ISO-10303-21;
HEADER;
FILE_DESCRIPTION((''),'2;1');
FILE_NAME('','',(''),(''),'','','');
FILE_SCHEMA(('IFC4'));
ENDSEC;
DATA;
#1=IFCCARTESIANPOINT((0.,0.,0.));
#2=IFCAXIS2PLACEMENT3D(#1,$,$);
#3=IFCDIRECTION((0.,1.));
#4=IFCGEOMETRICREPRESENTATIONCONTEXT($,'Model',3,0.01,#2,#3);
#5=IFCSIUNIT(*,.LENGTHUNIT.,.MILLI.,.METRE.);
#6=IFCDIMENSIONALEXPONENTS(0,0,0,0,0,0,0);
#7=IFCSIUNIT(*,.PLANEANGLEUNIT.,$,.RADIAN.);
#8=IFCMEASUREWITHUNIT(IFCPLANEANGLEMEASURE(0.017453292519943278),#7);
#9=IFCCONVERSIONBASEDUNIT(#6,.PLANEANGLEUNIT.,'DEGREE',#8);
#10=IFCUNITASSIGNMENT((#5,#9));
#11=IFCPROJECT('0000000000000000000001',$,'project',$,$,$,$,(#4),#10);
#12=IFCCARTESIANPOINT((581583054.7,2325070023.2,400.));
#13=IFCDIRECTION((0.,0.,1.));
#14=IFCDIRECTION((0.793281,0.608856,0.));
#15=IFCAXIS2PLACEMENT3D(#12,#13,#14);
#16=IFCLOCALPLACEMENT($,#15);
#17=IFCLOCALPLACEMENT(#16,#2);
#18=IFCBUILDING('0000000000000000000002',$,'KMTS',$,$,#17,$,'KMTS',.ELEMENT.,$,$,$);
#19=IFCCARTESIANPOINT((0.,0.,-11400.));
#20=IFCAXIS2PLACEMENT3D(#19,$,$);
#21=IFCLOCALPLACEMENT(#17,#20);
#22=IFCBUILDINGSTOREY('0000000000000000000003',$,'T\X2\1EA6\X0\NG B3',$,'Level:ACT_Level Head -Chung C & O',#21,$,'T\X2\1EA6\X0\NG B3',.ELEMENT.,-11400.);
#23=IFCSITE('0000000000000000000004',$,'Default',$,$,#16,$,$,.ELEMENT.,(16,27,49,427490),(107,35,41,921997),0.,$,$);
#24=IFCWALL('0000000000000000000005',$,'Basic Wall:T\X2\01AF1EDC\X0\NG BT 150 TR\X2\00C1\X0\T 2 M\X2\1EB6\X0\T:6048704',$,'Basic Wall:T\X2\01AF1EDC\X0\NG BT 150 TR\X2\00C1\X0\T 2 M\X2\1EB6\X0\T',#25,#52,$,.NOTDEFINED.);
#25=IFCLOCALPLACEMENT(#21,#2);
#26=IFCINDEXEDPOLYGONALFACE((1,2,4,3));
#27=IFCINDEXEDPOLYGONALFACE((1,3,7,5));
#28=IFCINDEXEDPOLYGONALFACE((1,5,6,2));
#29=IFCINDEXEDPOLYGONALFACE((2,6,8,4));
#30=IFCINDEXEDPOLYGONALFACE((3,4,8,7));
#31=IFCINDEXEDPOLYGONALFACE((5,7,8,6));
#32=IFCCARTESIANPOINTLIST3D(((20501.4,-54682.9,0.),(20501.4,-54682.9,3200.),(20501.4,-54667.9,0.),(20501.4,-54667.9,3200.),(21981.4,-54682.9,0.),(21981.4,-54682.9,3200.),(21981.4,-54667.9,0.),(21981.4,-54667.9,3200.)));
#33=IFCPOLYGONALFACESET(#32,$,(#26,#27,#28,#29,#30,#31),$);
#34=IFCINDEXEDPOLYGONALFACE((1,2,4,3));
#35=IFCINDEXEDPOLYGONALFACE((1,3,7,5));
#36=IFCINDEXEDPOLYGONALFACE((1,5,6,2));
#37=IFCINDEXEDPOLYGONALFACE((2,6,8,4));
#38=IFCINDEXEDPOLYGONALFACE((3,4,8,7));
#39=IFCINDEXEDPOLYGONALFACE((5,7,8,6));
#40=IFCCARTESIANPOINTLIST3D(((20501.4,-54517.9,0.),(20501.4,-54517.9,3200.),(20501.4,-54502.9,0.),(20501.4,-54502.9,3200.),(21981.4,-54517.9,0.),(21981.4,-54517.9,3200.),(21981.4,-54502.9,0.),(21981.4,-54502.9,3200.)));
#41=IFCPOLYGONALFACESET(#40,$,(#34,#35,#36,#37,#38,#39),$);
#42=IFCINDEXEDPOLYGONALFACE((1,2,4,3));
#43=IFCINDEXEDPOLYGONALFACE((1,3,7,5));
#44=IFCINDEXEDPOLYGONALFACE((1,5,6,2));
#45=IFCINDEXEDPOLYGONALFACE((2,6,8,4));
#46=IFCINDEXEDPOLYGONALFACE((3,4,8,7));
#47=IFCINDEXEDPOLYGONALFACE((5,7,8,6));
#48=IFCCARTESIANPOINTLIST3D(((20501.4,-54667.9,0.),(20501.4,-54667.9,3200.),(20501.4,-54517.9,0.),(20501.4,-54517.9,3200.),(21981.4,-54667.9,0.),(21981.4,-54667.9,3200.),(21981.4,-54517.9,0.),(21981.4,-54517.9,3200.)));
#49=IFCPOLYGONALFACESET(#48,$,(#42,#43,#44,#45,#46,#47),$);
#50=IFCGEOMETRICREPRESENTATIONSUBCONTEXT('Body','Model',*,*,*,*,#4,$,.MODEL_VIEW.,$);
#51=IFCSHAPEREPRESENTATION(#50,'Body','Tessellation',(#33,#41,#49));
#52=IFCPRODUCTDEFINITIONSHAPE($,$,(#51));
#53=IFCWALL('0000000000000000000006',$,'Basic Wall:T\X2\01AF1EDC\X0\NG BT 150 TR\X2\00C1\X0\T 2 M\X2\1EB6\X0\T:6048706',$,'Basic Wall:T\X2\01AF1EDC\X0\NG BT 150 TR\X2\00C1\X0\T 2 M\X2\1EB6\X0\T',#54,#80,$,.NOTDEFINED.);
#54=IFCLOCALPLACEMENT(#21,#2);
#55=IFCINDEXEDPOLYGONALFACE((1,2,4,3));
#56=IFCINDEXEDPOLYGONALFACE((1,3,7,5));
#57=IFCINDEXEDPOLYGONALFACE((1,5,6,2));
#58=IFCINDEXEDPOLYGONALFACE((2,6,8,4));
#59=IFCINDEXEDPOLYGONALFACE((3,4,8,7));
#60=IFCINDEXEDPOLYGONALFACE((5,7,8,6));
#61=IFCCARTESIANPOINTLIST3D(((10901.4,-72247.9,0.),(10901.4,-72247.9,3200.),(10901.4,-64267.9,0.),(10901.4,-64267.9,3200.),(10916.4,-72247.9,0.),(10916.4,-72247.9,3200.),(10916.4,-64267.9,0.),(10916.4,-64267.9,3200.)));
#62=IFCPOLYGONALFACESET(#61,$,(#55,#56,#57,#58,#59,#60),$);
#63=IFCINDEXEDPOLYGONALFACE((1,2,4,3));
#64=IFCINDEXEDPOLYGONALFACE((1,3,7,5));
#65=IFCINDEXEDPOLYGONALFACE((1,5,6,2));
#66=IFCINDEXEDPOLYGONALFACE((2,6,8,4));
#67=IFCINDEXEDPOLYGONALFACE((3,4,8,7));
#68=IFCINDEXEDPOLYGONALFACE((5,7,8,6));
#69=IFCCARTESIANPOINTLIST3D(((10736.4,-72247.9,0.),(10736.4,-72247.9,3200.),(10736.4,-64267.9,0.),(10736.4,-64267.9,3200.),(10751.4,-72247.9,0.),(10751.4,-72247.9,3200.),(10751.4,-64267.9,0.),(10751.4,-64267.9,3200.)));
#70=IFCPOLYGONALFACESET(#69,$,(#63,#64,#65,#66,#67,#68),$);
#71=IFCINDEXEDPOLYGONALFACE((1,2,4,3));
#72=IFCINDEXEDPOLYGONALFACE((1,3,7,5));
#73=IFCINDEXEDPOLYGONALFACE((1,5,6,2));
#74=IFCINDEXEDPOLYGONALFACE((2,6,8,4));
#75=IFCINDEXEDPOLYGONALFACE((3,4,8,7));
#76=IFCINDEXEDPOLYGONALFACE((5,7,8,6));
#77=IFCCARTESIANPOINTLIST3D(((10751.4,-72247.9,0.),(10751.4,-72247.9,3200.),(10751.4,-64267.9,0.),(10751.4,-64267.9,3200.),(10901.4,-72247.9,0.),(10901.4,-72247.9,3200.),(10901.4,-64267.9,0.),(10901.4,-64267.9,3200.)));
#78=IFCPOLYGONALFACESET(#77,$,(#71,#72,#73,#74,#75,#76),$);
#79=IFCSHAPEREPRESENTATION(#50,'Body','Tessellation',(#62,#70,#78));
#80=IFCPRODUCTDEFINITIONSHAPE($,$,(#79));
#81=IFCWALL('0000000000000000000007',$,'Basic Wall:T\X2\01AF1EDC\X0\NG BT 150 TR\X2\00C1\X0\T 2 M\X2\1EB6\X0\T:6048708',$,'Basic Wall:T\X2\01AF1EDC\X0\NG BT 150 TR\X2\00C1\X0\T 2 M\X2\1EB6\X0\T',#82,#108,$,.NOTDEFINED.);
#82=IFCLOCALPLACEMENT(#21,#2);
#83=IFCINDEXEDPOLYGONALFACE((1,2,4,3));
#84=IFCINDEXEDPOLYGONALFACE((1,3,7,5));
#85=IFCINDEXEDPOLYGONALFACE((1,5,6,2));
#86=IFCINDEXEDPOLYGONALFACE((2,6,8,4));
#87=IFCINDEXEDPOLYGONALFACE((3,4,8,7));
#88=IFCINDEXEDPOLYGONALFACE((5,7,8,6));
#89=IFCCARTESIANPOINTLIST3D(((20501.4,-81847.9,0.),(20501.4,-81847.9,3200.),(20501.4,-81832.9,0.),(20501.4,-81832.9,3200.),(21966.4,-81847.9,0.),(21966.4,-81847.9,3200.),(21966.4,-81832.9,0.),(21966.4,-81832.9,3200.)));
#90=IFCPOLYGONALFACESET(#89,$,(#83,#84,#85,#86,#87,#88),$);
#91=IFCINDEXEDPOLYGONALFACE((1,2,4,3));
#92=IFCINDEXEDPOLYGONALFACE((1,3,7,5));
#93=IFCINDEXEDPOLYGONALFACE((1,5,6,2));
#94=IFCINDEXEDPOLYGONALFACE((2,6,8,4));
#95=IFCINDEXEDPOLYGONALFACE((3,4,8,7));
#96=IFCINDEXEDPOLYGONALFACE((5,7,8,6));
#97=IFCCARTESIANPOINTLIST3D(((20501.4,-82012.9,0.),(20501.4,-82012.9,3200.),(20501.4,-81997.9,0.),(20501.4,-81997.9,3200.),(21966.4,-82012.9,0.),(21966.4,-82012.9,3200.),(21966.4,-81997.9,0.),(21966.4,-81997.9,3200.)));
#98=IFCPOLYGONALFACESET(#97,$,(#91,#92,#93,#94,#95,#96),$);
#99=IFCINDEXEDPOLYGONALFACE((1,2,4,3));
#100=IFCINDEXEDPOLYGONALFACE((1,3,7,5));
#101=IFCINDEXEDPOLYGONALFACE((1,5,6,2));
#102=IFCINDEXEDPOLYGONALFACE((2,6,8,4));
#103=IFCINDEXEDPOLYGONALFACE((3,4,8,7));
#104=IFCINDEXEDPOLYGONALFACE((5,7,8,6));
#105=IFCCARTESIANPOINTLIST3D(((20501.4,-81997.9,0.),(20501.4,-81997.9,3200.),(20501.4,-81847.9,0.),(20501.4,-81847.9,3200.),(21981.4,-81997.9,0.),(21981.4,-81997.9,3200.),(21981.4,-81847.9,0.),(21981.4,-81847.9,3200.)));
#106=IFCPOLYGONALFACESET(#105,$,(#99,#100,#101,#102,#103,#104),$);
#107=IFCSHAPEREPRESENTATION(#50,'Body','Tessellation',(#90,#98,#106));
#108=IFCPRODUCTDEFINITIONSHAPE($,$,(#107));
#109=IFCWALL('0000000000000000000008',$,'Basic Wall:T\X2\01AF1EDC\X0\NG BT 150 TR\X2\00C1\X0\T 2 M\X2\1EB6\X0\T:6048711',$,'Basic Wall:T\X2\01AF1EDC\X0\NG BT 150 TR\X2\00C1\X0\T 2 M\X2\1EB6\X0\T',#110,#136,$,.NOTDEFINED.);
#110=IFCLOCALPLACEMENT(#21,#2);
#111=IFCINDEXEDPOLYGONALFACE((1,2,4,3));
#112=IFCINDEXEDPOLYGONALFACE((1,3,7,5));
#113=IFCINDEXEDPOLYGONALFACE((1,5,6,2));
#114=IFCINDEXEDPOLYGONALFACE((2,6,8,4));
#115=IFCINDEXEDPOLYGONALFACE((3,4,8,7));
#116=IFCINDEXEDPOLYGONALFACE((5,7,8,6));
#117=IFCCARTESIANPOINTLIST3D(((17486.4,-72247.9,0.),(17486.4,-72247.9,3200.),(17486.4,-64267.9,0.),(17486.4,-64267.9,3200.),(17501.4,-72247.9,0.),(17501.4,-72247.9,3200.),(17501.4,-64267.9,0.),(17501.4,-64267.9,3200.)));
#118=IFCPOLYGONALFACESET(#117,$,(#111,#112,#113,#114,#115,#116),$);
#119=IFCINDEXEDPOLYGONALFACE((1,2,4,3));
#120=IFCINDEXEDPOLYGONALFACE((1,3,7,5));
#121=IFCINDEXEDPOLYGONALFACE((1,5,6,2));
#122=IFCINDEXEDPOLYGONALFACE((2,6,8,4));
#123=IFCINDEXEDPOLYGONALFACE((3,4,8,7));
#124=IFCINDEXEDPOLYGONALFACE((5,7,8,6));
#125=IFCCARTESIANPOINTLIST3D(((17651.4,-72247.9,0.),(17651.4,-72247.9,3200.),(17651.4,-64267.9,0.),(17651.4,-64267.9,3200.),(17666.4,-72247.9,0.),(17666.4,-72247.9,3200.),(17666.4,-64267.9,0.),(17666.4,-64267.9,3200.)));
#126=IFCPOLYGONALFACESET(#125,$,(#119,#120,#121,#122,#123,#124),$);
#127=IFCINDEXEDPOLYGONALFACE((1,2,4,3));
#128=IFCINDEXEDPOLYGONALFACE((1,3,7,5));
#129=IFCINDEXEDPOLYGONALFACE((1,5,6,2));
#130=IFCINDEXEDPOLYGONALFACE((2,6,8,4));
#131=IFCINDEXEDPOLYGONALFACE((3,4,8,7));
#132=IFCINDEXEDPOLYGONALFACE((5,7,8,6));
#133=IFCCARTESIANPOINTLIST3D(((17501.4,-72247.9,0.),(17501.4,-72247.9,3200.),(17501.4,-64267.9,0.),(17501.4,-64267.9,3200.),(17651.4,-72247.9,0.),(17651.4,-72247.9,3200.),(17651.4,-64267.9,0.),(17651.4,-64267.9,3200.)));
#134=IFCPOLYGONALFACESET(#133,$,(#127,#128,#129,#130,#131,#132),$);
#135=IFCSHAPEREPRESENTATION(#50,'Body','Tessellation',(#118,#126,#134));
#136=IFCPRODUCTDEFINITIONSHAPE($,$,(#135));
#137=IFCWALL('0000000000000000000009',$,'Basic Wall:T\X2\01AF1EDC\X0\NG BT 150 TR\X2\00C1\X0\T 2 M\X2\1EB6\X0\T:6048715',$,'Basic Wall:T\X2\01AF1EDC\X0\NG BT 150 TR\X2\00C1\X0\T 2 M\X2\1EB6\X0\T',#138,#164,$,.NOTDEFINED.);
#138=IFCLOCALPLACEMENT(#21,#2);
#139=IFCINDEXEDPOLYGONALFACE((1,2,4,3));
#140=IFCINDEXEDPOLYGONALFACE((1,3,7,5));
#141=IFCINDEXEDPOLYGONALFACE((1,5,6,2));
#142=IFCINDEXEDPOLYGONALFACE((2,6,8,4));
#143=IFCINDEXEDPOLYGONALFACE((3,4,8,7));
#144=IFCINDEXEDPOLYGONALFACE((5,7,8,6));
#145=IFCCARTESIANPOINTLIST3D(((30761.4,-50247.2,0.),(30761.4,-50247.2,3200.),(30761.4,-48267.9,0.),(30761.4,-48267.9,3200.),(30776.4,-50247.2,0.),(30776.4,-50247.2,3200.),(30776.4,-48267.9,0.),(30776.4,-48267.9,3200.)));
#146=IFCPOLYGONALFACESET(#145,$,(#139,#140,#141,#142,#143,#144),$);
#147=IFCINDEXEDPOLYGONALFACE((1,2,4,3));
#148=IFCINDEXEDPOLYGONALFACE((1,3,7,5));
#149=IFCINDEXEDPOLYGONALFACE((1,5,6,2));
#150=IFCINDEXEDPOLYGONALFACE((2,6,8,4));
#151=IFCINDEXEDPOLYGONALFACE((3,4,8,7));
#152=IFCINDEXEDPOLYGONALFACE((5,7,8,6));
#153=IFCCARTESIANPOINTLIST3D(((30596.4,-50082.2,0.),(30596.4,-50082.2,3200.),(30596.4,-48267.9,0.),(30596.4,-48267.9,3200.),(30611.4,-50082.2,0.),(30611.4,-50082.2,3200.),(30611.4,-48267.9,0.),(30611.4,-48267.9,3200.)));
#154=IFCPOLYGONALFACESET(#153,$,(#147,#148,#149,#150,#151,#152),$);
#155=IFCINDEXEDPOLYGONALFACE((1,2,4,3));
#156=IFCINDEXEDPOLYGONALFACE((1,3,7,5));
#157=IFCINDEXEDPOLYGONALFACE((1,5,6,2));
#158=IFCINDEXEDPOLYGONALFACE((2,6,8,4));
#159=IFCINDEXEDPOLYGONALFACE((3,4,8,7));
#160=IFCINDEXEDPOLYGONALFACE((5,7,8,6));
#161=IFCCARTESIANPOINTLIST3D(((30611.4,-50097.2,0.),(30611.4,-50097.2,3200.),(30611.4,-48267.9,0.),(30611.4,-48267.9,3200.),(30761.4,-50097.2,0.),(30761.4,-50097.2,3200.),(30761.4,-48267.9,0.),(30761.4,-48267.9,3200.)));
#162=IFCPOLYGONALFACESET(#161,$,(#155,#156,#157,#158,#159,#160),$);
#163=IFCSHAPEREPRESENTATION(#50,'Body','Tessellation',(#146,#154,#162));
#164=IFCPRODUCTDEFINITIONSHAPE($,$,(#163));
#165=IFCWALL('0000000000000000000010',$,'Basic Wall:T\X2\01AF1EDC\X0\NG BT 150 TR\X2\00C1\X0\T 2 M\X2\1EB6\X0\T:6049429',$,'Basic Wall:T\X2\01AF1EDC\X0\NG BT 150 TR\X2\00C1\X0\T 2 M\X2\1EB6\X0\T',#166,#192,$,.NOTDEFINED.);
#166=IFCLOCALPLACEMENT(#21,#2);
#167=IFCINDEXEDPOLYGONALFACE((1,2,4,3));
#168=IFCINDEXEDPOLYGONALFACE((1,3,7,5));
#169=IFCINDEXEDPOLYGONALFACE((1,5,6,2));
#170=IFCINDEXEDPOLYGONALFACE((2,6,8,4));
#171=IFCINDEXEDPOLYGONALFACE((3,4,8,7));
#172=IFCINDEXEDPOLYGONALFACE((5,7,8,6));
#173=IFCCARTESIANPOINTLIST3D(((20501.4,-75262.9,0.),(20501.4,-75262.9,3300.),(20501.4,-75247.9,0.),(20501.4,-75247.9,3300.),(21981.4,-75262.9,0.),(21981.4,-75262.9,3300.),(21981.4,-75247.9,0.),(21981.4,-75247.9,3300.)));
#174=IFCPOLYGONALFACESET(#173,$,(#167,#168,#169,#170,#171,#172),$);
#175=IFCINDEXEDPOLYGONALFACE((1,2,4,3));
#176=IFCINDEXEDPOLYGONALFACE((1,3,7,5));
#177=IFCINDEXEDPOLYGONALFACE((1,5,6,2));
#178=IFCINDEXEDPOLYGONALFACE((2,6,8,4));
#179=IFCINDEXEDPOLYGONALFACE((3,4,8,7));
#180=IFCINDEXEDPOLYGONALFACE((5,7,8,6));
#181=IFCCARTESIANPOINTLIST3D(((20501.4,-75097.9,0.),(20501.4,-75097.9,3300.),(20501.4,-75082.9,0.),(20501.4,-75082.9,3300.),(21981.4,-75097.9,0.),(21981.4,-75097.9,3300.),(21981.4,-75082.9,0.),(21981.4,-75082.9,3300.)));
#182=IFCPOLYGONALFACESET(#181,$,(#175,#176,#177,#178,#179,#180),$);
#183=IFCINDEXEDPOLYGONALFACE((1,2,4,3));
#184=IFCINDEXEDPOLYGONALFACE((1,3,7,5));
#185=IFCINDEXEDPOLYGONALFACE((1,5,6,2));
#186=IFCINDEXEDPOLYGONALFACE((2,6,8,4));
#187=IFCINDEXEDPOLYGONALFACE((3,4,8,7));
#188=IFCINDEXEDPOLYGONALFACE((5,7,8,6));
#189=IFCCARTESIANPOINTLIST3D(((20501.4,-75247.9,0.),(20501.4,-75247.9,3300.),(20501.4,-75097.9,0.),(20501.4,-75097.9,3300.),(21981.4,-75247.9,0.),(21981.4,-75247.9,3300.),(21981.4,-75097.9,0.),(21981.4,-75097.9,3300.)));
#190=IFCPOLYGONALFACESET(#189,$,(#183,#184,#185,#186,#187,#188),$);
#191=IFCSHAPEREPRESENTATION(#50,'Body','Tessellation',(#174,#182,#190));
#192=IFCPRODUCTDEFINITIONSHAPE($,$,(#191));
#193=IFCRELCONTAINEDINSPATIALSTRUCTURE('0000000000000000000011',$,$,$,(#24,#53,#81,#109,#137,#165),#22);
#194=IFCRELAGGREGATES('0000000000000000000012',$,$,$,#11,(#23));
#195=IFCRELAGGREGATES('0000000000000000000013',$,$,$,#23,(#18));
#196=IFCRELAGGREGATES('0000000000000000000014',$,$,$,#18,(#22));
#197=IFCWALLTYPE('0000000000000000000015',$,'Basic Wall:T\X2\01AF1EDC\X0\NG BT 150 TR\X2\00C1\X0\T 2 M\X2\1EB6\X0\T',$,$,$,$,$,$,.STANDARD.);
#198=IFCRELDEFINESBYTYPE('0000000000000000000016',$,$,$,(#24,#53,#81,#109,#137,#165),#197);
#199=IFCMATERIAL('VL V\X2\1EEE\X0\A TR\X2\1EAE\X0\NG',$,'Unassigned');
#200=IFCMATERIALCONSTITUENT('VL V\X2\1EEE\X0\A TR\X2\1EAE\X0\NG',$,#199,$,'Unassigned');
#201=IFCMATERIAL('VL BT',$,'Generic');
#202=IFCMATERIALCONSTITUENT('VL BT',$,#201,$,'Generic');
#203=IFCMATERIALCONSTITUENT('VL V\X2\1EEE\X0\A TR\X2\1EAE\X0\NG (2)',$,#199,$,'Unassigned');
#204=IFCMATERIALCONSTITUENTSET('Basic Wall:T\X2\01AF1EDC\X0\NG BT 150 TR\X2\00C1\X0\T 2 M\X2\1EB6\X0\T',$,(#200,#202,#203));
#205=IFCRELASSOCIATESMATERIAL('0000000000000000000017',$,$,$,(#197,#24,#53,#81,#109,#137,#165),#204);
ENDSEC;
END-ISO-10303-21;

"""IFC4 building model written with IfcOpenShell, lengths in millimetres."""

from ifc_helpers import new_model, entity, si_unit, converted_unit, direction, frame, origin, place, context, subcontext, project, spatial, indexed_curve, outline, extrude, material, constituent, constituent_set, type_object, element, save


model = new_model("IFC4")

# Units and contexts
model_context = context("Model", 3, precision=0.01, world=origin(), true_north=direction((0.0, 1.0)))
body_context = subcontext(model_context, "Body", "Model", "MODEL_VIEW")
ifc_project = project(units=[si_unit("LENGTHUNIT", "METRE", prefix="MILLI"), converted_unit("PLANEANGLEUNIT", "DEGREE", entity("IfcPlaneAngleMeasure", 0.017453292519943278), si_unit("PLANEANGLEUNIT", "RADIAN"), dimensions=[0, 0, 0, 0, 0, 0, 0])], contexts=[model_context])

# Site, building, storey
site_placement = place(None, frame((581583054.7, 2325070023.2, 400.0), z_axis=(0.0, 0.0, 1.0), x_axis=(0.793281, 0.608856, 0.0)))
site = spatial("IfcSite", under=ifc_project, at=site_placement, Name="Default", CompositionType="ELEMENT", RefLatitude=(16, 27, 49, 427490), RefLongitude=(107, 35, 41, 921997), RefElevation=0.0)
building_placement = place(site_placement, origin())
building = spatial("IfcBuilding", under=site, at=building_placement, Name="KMTS", LongName="KMTS", CompositionType="ELEMENT")
storey_placement = place(building_placement, frame((0.0, 0.0, -11400.0)))
storey = spatial("IfcBuildingStorey", under=building, at=storey_placement, Name="TẦNG B3", ObjectType="Level:ACT_Level Head -Chung C & O", LongName="TẦNG B3", CompositionType="ELEMENT", Elevation=-11400.0)

# Walls
ifc_material_1 = material(Name="VL VỮA TRẮNG", Category="Unassigned")
ifc_constituent_1 = constituent(ifc_material_1, Name="VL VỮA TRẮNG", Category="Unassigned")
ifc_material_2 = material(Name="VL BT", Category="Generic")
ifc_constituent_2 = constituent(ifc_material_2, Name="VL BT", Category="Generic")
ifc_constituent_3 = constituent(ifc_material_1, Name="VL VỮA TRẮNG (2)", Category="Unassigned")
ifc_constituent_set_1 = constituent_set(constituents=[ifc_constituent_1, ifc_constituent_2, ifc_constituent_3], Name="Basic Wall:TƯỜNG BT 150 TRÁT 2 MẶT")
wall_type_1 = type_object("IfcWallType", Name="Basic Wall:TƯỜNG BT 150 TRÁT 2 MẶT", PredefinedType="STANDARD", material=ifc_constituent_set_1)
wall_1_placement = place(storey_placement, frame((20501.4, -54592.9, 0.0)))
element("IfcWall", 1, at=wall_1_placement, inside=storey, type_object=wall_type_1, material=ifc_constituent_set_1, Name="Basic Wall:TƯỜNG BT 150 TRÁT 2 MẶT:6048704", ObjectType="Basic Wall:TƯỜNG BT 150 TRÁT 2 MẶT", PredefinedType="NOTDEFINED", context=body_context, shape_type="SweptSolid", body=[
    extrude(outline(indexed_curve([(-7.5, -740.0), (7.5, -740.0), (7.5, 740.0), (-7.5, 740.0), (-7.5, -740.0)], self_intersect=False)), frame((740.0, -82.5, 0.0), z_axis=(0.0, 0.0, 1.0), x_axis=(0.0, 1.0, 0.0)), (0.0, 0.0, 1.0), 3200.0),
    extrude(outline(indexed_curve([(-7.5, -740.0), (7.5, -740.0), (7.5, 740.0), (-7.5, 740.0), (-7.5, -740.0)], self_intersect=False)), frame((740.0, 82.5, 0.0), z_axis=(0.0, 0.0, 1.0), x_axis=(0.0, -1.0, 0.0)), (0.0, 0.0, 1.0), 3200.0),
    extrude(outline(indexed_curve([(-740.0, -75.0), (740.0, -75.0), (740.0, 75.0), (-740.0, 75.0), (-740.0, -75.0)], self_intersect=False)), frame((740.0, 0.0, 0.0)), (0.0, 0.0, 1.0), 3200.0),
])
wall_2_placement = place(storey_placement, frame((10826.4, -72247.9, 0.0), z_axis=(0.0, 0.0, 1.0), x_axis=(0.0, 1.0, 0.0)))
element("IfcWall", 2, at=wall_2_placement, inside=storey, type_object=wall_type_1, material=ifc_constituent_set_1, Name="Basic Wall:TƯỜNG BT 150 TRÁT 2 MẶT:6048706", ObjectType="Basic Wall:TƯỜNG BT 150 TRÁT 2 MẶT", PredefinedType="NOTDEFINED", context=body_context, shape_type="SweptSolid", body=[
    extrude(outline(indexed_curve([(-7.5, -3990.0), (7.5, -3990.0), (7.5, 3990.0), (-7.5, 3990.0), (-7.5, -3990.0)], self_intersect=False)), frame((3990.0, -82.5, 0.0), z_axis=(0.0, 0.0, 1.0), x_axis=(0.0, 1.0, 0.0)), (0.0, 0.0, 1.0), 3200.0),
    extrude(outline(indexed_curve([(-7.5, -3990.0), (7.5, -3990.0), (7.5, 3990.0), (-7.5, 3990.0), (-7.5, -3990.0)], self_intersect=False)), frame((3990.0, 82.5, 0.0), z_axis=(0.0, 0.0, 1.0), x_axis=(0.0, -1.0, 0.0)), (0.0, 0.0, 1.0), 3200.0),
    extrude(outline(indexed_curve([(-3990.0, -75.0), (3990.0, -75.0), (3990.0, 75.0), (-3990.0, 75.0), (-3990.0, -75.0)], self_intersect=False)), frame((3990.0, 0.0, 0.0)), (0.0, 0.0, 1.0), 3200.0),
])
wall_3_placement = place(storey_placement, frame((21966.4, -81922.9, 0.0), z_axis=(0.0, 0.0, 1.0), x_axis=(-1.0, 0.0, 0.0)))
element("IfcWall", 3, at=wall_3_placement, inside=storey, type_object=wall_type_1, material=ifc_constituent_set_1, Name="Basic Wall:TƯỜNG BT 150 TRÁT 2 MẶT:6048708", ObjectType="Basic Wall:TƯỜNG BT 150 TRÁT 2 MẶT", PredefinedType="NOTDEFINED", context=body_context, shape_type="SweptSolid", body=[
    extrude(outline(indexed_curve([(-7.5, -732.5), (7.5, -732.5), (7.5, 732.5), (-7.5, 732.5), (-7.5, -732.5)], self_intersect=False)), frame((732.5, -82.5, 0.0), z_axis=(0.0, 0.0, 1.0), x_axis=(0.0, 1.0, 0.0)), (0.0, 0.0, 1.0), 3200.0),
    extrude(outline(indexed_curve([(-7.5, -732.5), (7.5, -732.5), (7.5, 732.5), (-7.5, 732.5), (-7.5, -732.5)], self_intersect=False)), frame((732.5, 82.5, 0.0), z_axis=(0.0, 0.0, 1.0), x_axis=(0.0, -1.0, 0.0)), (0.0, 0.0, 1.0), 3200.0),
    extrude(outline(indexed_curve([(-740.0, -75.0), (740.0, -75.0), (740.0, 75.0), (-740.0, 75.0), (-740.0, -75.0)], self_intersect=False)), frame((725.0, 0.0, 0.0)), (0.0, 0.0, 1.0), 3200.0),
])

# Wall
wall_4_placement = place(storey_placement, frame((17576.4, -64267.9, 0.0), z_axis=(0.0, 0.0, 1.0), x_axis=(0.0, -1.0, 0.0)))
element("IfcWall", 4, at=wall_4_placement, inside=storey, type_object=wall_type_1, material=ifc_constituent_set_1, Name="Basic Wall:TƯỜNG BT 150 TRÁT 2 MẶT:6048711", ObjectType="Basic Wall:TƯỜNG BT 150 TRÁT 2 MẶT", PredefinedType="NOTDEFINED", context=body_context, shape_type="SweptSolid", body=[
    extrude(outline(indexed_curve([(-7.5, -3990.0), (7.5, -3990.0), (7.5, 3990.0), (-7.5, 3990.0), (-7.5, -3990.0)], self_intersect=False)), frame((3990.0, -82.5, 0.0), z_axis=(0.0, 0.0, 1.0), x_axis=(0.0, 1.0, 0.0)), (0.0, 0.0, 1.0), 3200.0),
    extrude(outline(indexed_curve([(-7.5, -3990.0), (7.5, -3990.0), (7.5, 3990.0), (-7.5, 3990.0), (-7.5, -3990.0)], self_intersect=False)), frame((3990.0, 82.5, 0.0), z_axis=(0.0, 0.0, 1.0), x_axis=(0.0, -1.0, 0.0)), (0.0, 0.0, 1.0), 3200.0),
    extrude(outline(indexed_curve([(-3990.0, -75.0), (3990.0, -75.0), (3990.0, 75.0), (-3990.0, 75.0), (-3990.0, -75.0)], self_intersect=False)), frame((3990.0, 0.0, 0.0)), (0.0, 0.0, 1.0), 3200.0),
])

# Wall
wall_5_placement = place(storey_placement, frame((30686.4, -50082.2, 0.0), z_axis=(0.0, 0.0, 1.0), x_axis=(0.0, 1.0, 0.0)))
element("IfcWall", 5, at=wall_5_placement, inside=storey, type_object=wall_type_1, material=ifc_constituent_set_1, Name="Basic Wall:TƯỜNG BT 150 TRÁT 2 MẶT:6048715", ObjectType="Basic Wall:TƯỜNG BT 150 TRÁT 2 MẶT", PredefinedType="NOTDEFINED", context=body_context, shape_type="SweptSolid", body=[
    extrude(outline(indexed_curve([(-7.5, -989.6), (7.5, -989.6), (7.5, 989.6), (-7.5, 989.6), (-7.5, -989.6)], self_intersect=False)), frame((824.6, -82.5, 0.0), z_axis=(0.0, 0.0, 1.0), x_axis=(0.0, 1.0, 0.0)), (0.0, 0.0, 1.0), 3200.0),
    extrude(outline(indexed_curve([(-7.5, -907.1), (7.5, -907.1), (7.5, 907.1), (-7.5, 907.1), (-7.5, -907.1)], self_intersect=False)), frame((907.1, 82.5, 0.0), z_axis=(0.0, 0.0, 1.0), x_axis=(0.0, -1.0, 0.0)), (0.0, 0.0, 1.0), 3200.0),
    extrude(outline(indexed_curve([(-914.6, -75.0), (914.6, -75.0), (914.6, 75.0), (-914.6, 75.0), (-914.6, -75.0)], self_intersect=False)), frame((899.6, 0.0, 0.0)), (0.0, 0.0, 1.0), 3200.0),
])

# Wall
wall_6_placement = place(storey_placement, frame((20501.4, -75172.9, 0.0)))
element("IfcWall", 6, at=wall_6_placement, inside=storey, type_object=wall_type_1, material=ifc_constituent_set_1, Name="Basic Wall:TƯỜNG BT 150 TRÁT 2 MẶT:6049429", ObjectType="Basic Wall:TƯỜNG BT 150 TRÁT 2 MẶT", PredefinedType="NOTDEFINED", context=body_context, shape_type="SweptSolid", body=[
    extrude(outline(indexed_curve([(-7.5, -740.0), (7.5, -740.0), (7.5, 740.0), (-7.5, 740.0), (-7.5, -740.0)], self_intersect=False)), frame((740.0, -82.5, 0.0), z_axis=(0.0, 0.0, 1.0), x_axis=(0.0, 1.0, 0.0)), (0.0, 0.0, 1.0), 3300.0),
    extrude(outline(indexed_curve([(-7.5, -740.0), (7.5, -740.0), (7.5, 740.0), (-7.5, 740.0), (-7.5, -740.0)], self_intersect=False)), frame((740.0, 82.5, 0.0), z_axis=(0.0, 0.0, 1.0), x_axis=(0.0, -1.0, 0.0)), (0.0, 0.0, 1.0), 3300.0),
    extrude(outline(indexed_curve([(-740.0, -75.0), (740.0, -75.0), (740.0, 75.0), (-740.0, 75.0), (-740.0, -75.0)], self_intersect=False)), frame((740.0, 0.0, 0.0)), (0.0, 0.0, 1.0), 3300.0),
])

save(model, "model.ifc")
